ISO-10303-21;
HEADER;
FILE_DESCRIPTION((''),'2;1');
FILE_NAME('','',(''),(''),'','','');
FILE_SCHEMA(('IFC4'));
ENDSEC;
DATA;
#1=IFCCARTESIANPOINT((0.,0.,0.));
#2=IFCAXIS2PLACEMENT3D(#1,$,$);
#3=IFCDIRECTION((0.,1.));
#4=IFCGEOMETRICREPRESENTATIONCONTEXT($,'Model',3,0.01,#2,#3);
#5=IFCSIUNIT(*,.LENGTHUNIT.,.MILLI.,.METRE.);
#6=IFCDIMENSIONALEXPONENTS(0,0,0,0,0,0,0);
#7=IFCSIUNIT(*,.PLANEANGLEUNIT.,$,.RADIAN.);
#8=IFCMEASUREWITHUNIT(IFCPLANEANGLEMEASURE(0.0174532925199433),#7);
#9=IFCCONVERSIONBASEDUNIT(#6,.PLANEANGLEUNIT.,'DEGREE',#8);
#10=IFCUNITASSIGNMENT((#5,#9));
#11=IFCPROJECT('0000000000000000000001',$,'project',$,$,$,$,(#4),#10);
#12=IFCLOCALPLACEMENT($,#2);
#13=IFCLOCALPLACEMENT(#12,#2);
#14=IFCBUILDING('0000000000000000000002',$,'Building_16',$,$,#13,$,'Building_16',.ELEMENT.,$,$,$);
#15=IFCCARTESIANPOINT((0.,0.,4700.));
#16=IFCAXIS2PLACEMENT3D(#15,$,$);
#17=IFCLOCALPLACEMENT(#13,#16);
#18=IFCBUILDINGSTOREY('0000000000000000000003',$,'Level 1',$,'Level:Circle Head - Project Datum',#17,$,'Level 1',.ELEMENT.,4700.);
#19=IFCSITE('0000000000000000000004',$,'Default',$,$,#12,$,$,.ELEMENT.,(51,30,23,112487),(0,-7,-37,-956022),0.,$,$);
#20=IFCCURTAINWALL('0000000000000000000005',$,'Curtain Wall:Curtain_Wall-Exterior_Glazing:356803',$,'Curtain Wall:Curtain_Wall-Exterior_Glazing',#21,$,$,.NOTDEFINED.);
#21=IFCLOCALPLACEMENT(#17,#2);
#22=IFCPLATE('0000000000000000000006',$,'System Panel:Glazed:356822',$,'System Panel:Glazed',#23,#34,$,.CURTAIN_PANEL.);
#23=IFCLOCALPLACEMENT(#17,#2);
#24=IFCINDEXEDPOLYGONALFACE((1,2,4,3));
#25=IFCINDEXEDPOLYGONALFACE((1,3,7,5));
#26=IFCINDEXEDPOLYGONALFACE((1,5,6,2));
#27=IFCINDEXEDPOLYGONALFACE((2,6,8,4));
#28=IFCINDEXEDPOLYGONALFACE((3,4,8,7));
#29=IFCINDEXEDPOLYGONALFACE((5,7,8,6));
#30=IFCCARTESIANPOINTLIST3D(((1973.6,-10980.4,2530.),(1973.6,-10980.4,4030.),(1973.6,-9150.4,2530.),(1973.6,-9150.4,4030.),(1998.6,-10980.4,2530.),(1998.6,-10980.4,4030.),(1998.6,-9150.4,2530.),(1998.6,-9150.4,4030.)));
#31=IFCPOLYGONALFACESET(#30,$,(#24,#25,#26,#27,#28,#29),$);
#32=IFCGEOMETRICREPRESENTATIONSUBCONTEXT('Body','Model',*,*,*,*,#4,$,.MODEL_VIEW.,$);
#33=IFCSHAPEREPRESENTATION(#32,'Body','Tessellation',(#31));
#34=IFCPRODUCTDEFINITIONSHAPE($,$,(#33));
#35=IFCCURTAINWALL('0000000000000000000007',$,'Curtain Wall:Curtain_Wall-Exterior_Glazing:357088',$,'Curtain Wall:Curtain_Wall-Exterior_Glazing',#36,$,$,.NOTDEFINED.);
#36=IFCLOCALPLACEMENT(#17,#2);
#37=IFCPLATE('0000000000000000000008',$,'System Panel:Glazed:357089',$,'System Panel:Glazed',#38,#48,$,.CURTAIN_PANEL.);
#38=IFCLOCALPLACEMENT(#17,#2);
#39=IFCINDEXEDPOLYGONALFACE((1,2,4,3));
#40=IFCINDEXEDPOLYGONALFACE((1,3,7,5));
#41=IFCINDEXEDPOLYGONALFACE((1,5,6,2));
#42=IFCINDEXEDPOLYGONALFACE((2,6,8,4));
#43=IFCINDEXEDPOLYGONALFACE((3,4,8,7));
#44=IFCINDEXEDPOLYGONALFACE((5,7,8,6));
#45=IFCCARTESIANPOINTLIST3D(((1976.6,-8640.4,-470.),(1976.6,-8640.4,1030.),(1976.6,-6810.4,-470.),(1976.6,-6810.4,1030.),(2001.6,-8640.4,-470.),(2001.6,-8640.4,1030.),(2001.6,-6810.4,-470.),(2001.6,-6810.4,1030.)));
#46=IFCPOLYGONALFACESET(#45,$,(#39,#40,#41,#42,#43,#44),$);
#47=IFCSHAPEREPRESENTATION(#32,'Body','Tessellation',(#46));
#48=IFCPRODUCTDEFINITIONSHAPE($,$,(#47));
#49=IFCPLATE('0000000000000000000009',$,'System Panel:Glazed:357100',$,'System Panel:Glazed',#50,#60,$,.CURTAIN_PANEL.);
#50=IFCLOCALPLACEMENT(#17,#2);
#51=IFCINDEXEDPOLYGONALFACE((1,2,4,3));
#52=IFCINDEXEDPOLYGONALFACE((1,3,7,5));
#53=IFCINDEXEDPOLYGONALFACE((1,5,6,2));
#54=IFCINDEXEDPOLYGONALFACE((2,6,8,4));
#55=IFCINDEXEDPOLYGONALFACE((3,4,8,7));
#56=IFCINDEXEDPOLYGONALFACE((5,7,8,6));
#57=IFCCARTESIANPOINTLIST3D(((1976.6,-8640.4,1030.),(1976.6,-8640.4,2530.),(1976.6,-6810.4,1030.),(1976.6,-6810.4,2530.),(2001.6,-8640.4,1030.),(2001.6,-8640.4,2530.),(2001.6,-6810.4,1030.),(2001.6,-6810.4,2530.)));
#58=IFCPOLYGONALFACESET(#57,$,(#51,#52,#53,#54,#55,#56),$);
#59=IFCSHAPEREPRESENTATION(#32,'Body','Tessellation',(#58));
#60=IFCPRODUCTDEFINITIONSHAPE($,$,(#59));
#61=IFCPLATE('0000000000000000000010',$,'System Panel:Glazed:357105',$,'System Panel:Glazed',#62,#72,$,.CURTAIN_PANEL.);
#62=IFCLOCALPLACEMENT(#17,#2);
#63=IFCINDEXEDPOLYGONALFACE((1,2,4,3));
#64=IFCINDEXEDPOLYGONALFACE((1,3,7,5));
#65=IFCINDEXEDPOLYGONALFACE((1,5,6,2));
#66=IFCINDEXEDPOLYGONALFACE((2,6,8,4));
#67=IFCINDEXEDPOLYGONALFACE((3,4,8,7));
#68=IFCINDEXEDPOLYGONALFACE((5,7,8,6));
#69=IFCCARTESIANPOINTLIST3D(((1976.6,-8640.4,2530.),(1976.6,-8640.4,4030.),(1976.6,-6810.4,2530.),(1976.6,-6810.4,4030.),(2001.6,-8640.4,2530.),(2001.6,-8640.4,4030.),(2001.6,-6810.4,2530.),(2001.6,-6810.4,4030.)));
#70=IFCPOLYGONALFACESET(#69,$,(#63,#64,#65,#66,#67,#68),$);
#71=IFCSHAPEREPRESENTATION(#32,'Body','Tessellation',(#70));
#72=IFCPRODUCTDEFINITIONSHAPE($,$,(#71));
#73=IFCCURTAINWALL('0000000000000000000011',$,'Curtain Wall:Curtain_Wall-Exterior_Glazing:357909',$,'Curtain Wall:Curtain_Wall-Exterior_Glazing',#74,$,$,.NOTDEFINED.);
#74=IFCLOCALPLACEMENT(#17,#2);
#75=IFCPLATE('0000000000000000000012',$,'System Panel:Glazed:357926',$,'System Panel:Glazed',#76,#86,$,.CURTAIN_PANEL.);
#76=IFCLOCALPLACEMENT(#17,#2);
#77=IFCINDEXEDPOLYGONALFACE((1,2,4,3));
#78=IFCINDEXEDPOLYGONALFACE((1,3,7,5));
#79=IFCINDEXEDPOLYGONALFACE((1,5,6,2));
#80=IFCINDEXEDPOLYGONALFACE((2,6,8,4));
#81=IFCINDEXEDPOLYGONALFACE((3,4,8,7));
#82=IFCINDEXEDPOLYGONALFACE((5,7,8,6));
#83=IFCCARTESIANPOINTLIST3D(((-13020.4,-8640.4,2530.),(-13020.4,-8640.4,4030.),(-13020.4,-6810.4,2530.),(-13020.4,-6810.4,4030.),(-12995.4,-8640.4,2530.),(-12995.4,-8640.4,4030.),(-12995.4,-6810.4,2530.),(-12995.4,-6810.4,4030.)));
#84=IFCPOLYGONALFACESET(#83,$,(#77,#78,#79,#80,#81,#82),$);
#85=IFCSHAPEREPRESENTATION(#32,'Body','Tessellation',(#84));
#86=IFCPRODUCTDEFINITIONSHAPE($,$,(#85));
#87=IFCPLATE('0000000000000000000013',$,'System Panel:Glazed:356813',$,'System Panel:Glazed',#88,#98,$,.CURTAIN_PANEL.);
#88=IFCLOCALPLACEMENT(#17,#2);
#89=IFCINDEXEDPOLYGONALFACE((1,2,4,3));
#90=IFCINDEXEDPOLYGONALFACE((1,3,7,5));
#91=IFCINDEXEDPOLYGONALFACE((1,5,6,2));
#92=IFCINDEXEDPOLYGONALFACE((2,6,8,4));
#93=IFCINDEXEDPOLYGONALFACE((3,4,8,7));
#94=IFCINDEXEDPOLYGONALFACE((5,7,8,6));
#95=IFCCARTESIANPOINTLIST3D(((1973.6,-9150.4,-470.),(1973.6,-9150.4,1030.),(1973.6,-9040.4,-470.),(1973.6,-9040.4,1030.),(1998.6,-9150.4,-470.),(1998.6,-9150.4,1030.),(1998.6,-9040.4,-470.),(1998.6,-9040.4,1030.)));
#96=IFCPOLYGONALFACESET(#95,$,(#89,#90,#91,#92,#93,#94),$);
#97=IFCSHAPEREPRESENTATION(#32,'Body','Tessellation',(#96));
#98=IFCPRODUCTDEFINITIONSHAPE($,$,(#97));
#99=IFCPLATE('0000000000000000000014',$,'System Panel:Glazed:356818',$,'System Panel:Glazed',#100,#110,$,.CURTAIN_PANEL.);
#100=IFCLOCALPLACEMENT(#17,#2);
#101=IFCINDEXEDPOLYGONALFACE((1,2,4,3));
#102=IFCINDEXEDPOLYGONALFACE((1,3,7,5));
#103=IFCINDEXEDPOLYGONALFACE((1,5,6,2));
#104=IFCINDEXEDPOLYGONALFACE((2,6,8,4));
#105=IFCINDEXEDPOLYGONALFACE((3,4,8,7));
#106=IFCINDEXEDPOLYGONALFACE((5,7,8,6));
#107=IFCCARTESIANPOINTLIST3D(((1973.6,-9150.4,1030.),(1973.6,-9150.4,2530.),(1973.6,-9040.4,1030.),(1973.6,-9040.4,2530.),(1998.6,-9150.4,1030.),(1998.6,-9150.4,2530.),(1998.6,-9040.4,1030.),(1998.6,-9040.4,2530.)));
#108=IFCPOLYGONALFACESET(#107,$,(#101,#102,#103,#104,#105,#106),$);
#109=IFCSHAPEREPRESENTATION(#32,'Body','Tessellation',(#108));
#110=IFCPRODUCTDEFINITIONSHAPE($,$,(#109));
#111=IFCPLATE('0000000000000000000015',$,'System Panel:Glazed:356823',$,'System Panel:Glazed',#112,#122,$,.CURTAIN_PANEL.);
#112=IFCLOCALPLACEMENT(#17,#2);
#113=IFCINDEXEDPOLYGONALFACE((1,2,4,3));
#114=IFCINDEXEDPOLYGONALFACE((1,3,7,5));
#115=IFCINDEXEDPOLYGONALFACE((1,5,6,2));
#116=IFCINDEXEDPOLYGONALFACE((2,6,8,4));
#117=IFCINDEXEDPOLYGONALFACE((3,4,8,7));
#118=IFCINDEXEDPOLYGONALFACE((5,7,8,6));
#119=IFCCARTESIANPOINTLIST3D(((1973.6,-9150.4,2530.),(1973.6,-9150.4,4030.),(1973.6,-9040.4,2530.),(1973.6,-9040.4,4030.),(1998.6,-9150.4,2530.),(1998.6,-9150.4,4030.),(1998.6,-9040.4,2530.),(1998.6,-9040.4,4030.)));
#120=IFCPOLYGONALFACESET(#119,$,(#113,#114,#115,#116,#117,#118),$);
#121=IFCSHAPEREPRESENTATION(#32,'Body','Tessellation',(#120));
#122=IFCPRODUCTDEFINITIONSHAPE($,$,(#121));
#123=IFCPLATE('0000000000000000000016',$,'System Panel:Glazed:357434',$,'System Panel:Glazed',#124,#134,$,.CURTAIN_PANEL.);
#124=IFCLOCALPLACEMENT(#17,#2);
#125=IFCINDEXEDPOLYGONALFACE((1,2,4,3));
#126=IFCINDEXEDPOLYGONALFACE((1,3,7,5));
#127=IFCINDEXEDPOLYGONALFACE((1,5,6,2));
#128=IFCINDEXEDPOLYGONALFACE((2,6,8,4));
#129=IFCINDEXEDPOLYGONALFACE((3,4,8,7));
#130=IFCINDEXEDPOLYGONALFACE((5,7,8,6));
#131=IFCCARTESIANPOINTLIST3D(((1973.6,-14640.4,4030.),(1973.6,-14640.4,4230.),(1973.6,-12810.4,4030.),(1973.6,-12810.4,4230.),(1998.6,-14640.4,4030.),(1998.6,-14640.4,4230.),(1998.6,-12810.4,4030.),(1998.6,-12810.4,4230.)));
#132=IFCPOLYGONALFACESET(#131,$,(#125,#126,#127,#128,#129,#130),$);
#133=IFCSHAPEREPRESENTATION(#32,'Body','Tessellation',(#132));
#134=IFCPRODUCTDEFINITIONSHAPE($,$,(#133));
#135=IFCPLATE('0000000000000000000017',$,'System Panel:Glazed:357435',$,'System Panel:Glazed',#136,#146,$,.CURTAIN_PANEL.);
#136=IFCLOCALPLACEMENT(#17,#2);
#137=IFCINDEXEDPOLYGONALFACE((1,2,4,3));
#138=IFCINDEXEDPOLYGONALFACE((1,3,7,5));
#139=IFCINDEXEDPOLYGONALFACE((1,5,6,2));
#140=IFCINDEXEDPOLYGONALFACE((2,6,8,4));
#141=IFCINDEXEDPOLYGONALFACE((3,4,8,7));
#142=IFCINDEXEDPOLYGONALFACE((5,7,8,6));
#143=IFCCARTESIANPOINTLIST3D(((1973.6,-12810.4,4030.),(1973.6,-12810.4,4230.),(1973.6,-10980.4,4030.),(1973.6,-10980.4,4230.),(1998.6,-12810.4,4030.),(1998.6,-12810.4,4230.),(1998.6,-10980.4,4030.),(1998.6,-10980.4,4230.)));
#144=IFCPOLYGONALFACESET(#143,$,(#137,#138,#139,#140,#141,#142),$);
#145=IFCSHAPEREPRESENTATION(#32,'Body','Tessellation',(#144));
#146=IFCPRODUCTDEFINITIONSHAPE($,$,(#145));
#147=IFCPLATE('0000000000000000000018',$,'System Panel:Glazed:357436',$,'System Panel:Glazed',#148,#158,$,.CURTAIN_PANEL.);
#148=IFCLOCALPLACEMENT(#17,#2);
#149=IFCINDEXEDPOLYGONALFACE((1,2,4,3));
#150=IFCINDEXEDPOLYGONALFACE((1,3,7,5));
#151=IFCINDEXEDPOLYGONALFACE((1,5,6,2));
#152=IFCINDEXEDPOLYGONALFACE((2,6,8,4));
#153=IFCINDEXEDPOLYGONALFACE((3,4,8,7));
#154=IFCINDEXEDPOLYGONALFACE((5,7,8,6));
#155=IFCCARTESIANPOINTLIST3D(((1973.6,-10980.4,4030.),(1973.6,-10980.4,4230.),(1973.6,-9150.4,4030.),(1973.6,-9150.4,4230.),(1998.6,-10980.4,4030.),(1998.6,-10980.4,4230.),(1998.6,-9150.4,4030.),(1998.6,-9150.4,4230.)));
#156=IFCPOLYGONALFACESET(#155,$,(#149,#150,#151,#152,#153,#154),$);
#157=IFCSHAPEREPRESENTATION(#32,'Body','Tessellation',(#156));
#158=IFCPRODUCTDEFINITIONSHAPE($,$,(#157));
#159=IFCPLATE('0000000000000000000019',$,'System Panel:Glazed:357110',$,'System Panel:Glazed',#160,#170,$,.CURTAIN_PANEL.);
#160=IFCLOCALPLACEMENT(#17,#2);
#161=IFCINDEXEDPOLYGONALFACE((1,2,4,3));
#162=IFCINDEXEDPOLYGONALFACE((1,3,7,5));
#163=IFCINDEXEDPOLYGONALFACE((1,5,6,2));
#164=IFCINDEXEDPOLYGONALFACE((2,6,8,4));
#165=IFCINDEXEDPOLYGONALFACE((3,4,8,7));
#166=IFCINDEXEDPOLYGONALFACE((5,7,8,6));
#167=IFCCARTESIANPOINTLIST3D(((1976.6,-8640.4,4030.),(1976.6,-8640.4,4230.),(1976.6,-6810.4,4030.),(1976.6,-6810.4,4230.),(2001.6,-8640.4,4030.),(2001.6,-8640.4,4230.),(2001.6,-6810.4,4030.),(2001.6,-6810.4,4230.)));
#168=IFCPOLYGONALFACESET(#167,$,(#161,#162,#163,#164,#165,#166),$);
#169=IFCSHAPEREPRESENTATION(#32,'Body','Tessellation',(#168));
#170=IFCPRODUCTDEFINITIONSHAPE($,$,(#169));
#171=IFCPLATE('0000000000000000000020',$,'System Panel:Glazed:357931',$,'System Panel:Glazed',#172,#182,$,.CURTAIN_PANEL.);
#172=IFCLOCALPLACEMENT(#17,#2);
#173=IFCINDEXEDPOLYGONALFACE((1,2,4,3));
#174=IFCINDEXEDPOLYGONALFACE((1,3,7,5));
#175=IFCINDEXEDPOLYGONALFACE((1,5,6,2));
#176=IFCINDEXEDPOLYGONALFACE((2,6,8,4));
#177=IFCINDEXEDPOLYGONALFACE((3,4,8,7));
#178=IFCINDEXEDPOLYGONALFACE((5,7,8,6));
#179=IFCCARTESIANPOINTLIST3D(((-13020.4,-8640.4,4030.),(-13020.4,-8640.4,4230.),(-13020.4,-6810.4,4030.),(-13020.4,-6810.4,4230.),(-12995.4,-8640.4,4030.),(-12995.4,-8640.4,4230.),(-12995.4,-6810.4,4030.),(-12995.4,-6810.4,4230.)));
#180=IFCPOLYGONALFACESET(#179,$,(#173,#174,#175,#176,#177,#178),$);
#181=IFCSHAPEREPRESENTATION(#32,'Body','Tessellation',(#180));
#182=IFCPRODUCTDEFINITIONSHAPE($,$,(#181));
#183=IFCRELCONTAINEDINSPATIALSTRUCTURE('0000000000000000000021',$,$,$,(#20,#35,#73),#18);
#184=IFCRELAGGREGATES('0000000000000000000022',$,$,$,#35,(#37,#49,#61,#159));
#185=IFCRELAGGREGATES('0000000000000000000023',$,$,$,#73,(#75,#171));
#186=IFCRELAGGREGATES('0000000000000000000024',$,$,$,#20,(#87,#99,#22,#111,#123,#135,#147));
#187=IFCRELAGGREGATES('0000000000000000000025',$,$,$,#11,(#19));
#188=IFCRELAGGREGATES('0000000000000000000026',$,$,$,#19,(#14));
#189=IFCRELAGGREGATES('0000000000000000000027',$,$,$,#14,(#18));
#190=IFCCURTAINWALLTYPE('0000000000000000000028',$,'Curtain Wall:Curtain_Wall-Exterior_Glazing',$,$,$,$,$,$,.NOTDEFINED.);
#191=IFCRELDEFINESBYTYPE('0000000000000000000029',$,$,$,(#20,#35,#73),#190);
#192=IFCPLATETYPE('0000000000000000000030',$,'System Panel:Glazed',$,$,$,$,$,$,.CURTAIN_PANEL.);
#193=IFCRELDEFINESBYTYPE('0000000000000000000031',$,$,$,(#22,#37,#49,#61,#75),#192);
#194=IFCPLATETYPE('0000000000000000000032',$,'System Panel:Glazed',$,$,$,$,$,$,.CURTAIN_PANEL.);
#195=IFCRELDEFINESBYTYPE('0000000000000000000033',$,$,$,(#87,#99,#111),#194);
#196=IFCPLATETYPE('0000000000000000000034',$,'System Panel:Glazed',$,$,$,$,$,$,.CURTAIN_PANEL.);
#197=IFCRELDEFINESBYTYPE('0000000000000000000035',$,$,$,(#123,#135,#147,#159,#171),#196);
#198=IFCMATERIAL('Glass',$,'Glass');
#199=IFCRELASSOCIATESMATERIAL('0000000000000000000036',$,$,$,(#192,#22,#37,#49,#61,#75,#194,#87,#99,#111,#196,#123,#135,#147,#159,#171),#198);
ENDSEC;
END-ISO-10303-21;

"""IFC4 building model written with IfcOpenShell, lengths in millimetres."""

from ifc_helpers import new_model, entity, si_unit, converted_unit, direction, frame, origin, place, context, subcontext, project, spatial, indexed_curve, outline, extrude, source, transform, mapped, material, type_object, type_shapes, element, aggregate, save


model = new_model("IFC4")

# Units and contexts
model_context = context("Model", 3, precision=0.01, world=origin(), true_north=direction((0.0, 1.0)))
body_context = subcontext(model_context, "Body", "Model", "MODEL_VIEW")
ifc_project = project(units=[si_unit("LENGTHUNIT", "METRE", prefix="MILLI"), converted_unit("PLANEANGLEUNIT", "DEGREE", entity("IfcPlaneAngleMeasure", 0.0174532925199433), si_unit("PLANEANGLEUNIT", "RADIAN"), dimensions=[0, 0, 0, 0, 0, 0, 0])], contexts=[model_context])

# Site, building, storey
site_placement = place(None, origin())
site = spatial("IfcSite", under=ifc_project, at=site_placement, Name="Default", CompositionType="ELEMENT", RefLatitude=(51, 30, 23, 112487), RefLongitude=(0, -7, -37, -956022), RefElevation=0.0)
building_placement = place(site_placement, origin())
building = spatial("IfcBuilding", under=site, at=building_placement, Name="Building_16", LongName="Building_16", CompositionType="ELEMENT")
storey_placement = place(building_placement, frame((0.0, 0.0, 4700.0)))
storey = spatial("IfcBuildingStorey", under=building, at=storey_placement, Name="Level 1", ObjectType="Level:Circle Head - Project Datum", LongName="Level 1", CompositionType="ELEMENT", Elevation=4700.0)

# Curtain walls, plates
curtain_wall_type = type_object("IfcCurtainWallType", Name="Curtain Wall:Curtain_Wall-Exterior_Glazing", PredefinedType="NOTDEFINED")
curtain_wall_1_placement = place(storey_placement, frame((0.0, 0.0, -4700.0)))
curtain_wall_1 = element("IfcCurtainWall", 1, at=curtain_wall_1_placement, inside=storey, type_object=curtain_wall_type, Name="Curtain Wall:Curtain_Wall-Exterior_Glazing:356803", ObjectType="Curtain Wall:Curtain_Wall-Exterior_Glazing", PredefinedType="NOTDEFINED")
ifc_material_1 = material(Name="Glass", Category="Glass")
plate_type_1 = type_object("IfcPlateType", Name="System Panel:Glazed", PredefinedType="CURTAIN_PANEL", material=ifc_material_1)
shared_shape_1 = source(origin(), body_context, "Body", "SweptSolid", [
    extrude(outline(indexed_curve([(-12.5, -915.0), (12.5, -915.0), (12.5, 915.0), (-12.5, 915.0), (-12.5, -915.0)], self_intersect=False)), frame((0.0, 37.0, 0.0), z_axis=(0.0, 0.0, 1.0), x_axis=(0.0, 1.0, 0.0)), (0.0, 0.0, 1.0), 1500.0),
])
type_shapes(plate_type_1, [shared_shape_1])
plate_1_placement = place(curtain_wall_1_placement, frame((2023.1, -10065.4, 7230.0), z_axis=(0.0, 0.0, 1.0), x_axis=(0.0, 1.0, 0.0)))
plate_1 = element("IfcPlate", 2, at=plate_1_placement, type_object=plate_type_1, material=ifc_material_1, Name="System Panel:Glazed:356822", ObjectType="System Panel:Glazed", PredefinedType="CURTAIN_PANEL", context=body_context, shape_type="MappedRepresentation", body=[
    mapped(shared_shape_1, transform((0.0, 0.0, 0.0), scale=1.0)),
])
curtain_wall_2_placement = place(storey_placement, frame((0.0, 0.0, -4700.0)))
curtain_wall_2 = element("IfcCurtainWall", 3, at=curtain_wall_2_placement, inside=storey, type_object=curtain_wall_type, Name="Curtain Wall:Curtain_Wall-Exterior_Glazing:357088", ObjectType="Curtain Wall:Curtain_Wall-Exterior_Glazing", PredefinedType="NOTDEFINED")
plate_2_placement = place(curtain_wall_2_placement, frame((2026.1, -7725.4, 4230.0), z_axis=(0.0, 0.0, 1.0), x_axis=(0.0, 1.0, 0.0)))
plate_2 = element("IfcPlate", 4, at=plate_2_placement, type_object=plate_type_1, material=ifc_material_1, Name="System Panel:Glazed:357089", ObjectType="System Panel:Glazed", PredefinedType="CURTAIN_PANEL", context=body_context, shape_type="MappedRepresentation", body=[
    mapped(shared_shape_1, transform((0.0, 0.0, 0.0), scale=1.0)),
])
plate_3_placement = place(curtain_wall_2_placement, frame((2026.1, -7725.4, 5730.0), z_axis=(0.0, 0.0, 1.0), x_axis=(0.0, 1.0, 0.0)))
plate_3 = element("IfcPlate", 5, at=plate_3_placement, type_object=plate_type_1, material=ifc_material_1, Name="System Panel:Glazed:357100", ObjectType="System Panel:Glazed", PredefinedType="CURTAIN_PANEL", context=body_context, shape_type="MappedRepresentation", body=[
    mapped(shared_shape_1, transform((0.0, 0.0, 0.0), scale=1.0)),
])
plate_4_placement = place(curtain_wall_2_placement, frame((2026.1, -7725.4, 7230.0), z_axis=(0.0, 0.0, 1.0), x_axis=(0.0, 1.0, 0.0)))
plate_4 = element("IfcPlate", 6, at=plate_4_placement, type_object=plate_type_1, material=ifc_material_1, Name="System Panel:Glazed:357105", ObjectType="System Panel:Glazed", PredefinedType="CURTAIN_PANEL", context=body_context, shape_type="MappedRepresentation", body=[
    mapped(shared_shape_1, transform((0.0, 0.0, 0.0), scale=1.0)),
])

# Curtain wall, plate
curtain_wall_3_placement = place(storey_placement, frame((0.0, 0.0, -4700.0)))
curtain_wall_3 = element("IfcCurtainWall", 7, at=curtain_wall_3_placement, inside=storey, type_object=curtain_wall_type, Name="Curtain Wall:Curtain_Wall-Exterior_Glazing:357909", ObjectType="Curtain Wall:Curtain_Wall-Exterior_Glazing", PredefinedType="NOTDEFINED")
plate_5_placement = place(curtain_wall_3_placement, frame((-12970.9, -7725.4, 7230.0), z_axis=(0.0, 0.0, 1.0), x_axis=(0.0, 1.0, 0.0)))
plate_5 = element("IfcPlate", 8, at=plate_5_placement, type_object=plate_type_1, material=ifc_material_1, Name="System Panel:Glazed:357926", ObjectType="System Panel:Glazed", PredefinedType="CURTAIN_PANEL", context=body_context, shape_type="MappedRepresentation", body=[
    mapped(shared_shape_1, transform((0.0, 0.0, 0.0), scale=1.0)),
])

# Plates
plate_type_2 = type_object("IfcPlateType", Name="System Panel:Glazed", PredefinedType="CURTAIN_PANEL", material=ifc_material_1)
shared_shape_2 = source(origin(), body_context, "Body", "SweptSolid", [
    extrude(outline(indexed_curve([(-12.5, -55.0), (12.5, -55.0), (12.5, 55.0), (-12.5, 55.0), (-12.5, -55.0)], self_intersect=False)), frame((0.0, 37.0, 0.0), z_axis=(0.0, 0.0, 1.0), x_axis=(0.0, 1.0, 0.0)), (0.0, 0.0, 1.0), 1500.0),
])
type_shapes(plate_type_2, [shared_shape_2])
plate_6_placement = place(curtain_wall_1_placement, frame((2023.1, -9095.4, 4230.0), z_axis=(0.0, 0.0, 1.0), x_axis=(0.0, 1.0, 0.0)))
plate_6 = element("IfcPlate", 9, at=plate_6_placement, type_object=plate_type_2, material=ifc_material_1, Name="System Panel:Glazed:356813", ObjectType="System Panel:Glazed", PredefinedType="CURTAIN_PANEL", context=body_context, shape_type="MappedRepresentation", body=[
    mapped(shared_shape_2, transform((0.0, 0.0, 0.0), scale=1.0)),
])
plate_7_placement = place(curtain_wall_1_placement, frame((2023.1, -9095.4, 5730.0), z_axis=(0.0, 0.0, 1.0), x_axis=(0.0, 1.0, 0.0)))
plate_7 = element("IfcPlate", 10, at=plate_7_placement, type_object=plate_type_2, material=ifc_material_1, Name="System Panel:Glazed:356818", ObjectType="System Panel:Glazed", PredefinedType="CURTAIN_PANEL", context=body_context, shape_type="MappedRepresentation", body=[
    mapped(shared_shape_2, transform((0.0, 0.0, 0.0), scale=1.0)),
])
plate_8_placement = place(curtain_wall_1_placement, frame((2023.1, -9095.4, 7230.0), z_axis=(0.0, 0.0, 1.0), x_axis=(0.0, 1.0, 0.0)))
plate_8 = element("IfcPlate", 11, at=plate_8_placement, type_object=plate_type_2, material=ifc_material_1, Name="System Panel:Glazed:356823", ObjectType="System Panel:Glazed", PredefinedType="CURTAIN_PANEL", context=body_context, shape_type="MappedRepresentation", body=[
    mapped(shared_shape_2, transform((0.0, 0.0, 0.0), scale=1.0)),
])
plate_type_3 = type_object("IfcPlateType", Name="System Panel:Glazed", PredefinedType="CURTAIN_PANEL", material=ifc_material_1)
shared_shape_3 = source(origin(), body_context, "Body", "SweptSolid", [
    extrude(outline(indexed_curve([(-12.5, -915.0), (12.5, -915.0), (12.5, 915.0), (-12.5, 915.0), (-12.5, -915.0)], self_intersect=False)), frame((0.0, 37.0, 0.0), z_axis=(0.0, 0.0, 1.0), x_axis=(0.0, 1.0, 0.0)), (0.0, 0.0, 1.0), 200.0),
])
type_shapes(plate_type_3, [shared_shape_3])
plate_9_placement = place(curtain_wall_1_placement, frame((2023.1, -13725.4, 8730.0), z_axis=(0.0, 0.0, 1.0), x_axis=(0.0, 1.0, 0.0)))
plate_9 = element("IfcPlate", 12, at=plate_9_placement, type_object=plate_type_3, material=ifc_material_1, Name="System Panel:Glazed:357434", ObjectType="System Panel:Glazed", PredefinedType="CURTAIN_PANEL", context=body_context, shape_type="MappedRepresentation", body=[
    mapped(shared_shape_3, transform((0.0, 0.0, 0.0), scale=1.0)),
])
plate_10_placement = place(curtain_wall_1_placement, frame((2023.1, -11895.4, 8730.0), z_axis=(0.0, 0.0, 1.0), x_axis=(0.0, 1.0, 0.0)))
plate_10 = element("IfcPlate", 13, at=plate_10_placement, type_object=plate_type_3, material=ifc_material_1, Name="System Panel:Glazed:357435", ObjectType="System Panel:Glazed", PredefinedType="CURTAIN_PANEL", context=body_context, shape_type="MappedRepresentation", body=[
    mapped(shared_shape_3, transform((0.0, 0.0, 0.0), scale=1.0)),
])
plate_11_placement = place(curtain_wall_1_placement, frame((2023.1, -10065.4, 8730.0), z_axis=(0.0, 0.0, 1.0), x_axis=(0.0, 1.0, 0.0)))
plate_11 = element("IfcPlate", 14, at=plate_11_placement, type_object=plate_type_3, material=ifc_material_1, Name="System Panel:Glazed:357436", ObjectType="System Panel:Glazed", PredefinedType="CURTAIN_PANEL", context=body_context, shape_type="MappedRepresentation", body=[
    mapped(shared_shape_3, transform((0.0, 0.0, 0.0), scale=1.0)),
])
plate_12_placement = place(curtain_wall_2_placement, frame((2026.1, -7725.4, 8730.0), z_axis=(0.0, 0.0, 1.0), x_axis=(0.0, 1.0, 0.0)))
plate_12 = element("IfcPlate", 15, at=plate_12_placement, type_object=plate_type_3, material=ifc_material_1, Name="System Panel:Glazed:357110", ObjectType="System Panel:Glazed", PredefinedType="CURTAIN_PANEL", context=body_context, shape_type="MappedRepresentation", body=[
    mapped(shared_shape_3, transform((0.0, 0.0, 0.0), scale=1.0)),
])
aggregate(curtain_wall_2, [plate_2, plate_3, plate_4, plate_12])
plate_13_placement = place(curtain_wall_3_placement, frame((-12970.9, -7725.4, 8730.0), z_axis=(0.0, 0.0, 1.0), x_axis=(0.0, 1.0, 0.0)))
plate_13 = element("IfcPlate", 16, at=plate_13_placement, type_object=plate_type_3, material=ifc_material_1, Name="System Panel:Glazed:357931", ObjectType="System Panel:Glazed", PredefinedType="CURTAIN_PANEL", context=body_context, shape_type="MappedRepresentation", body=[
    mapped(shared_shape_3, transform((0.0, 0.0, 0.0), scale=1.0)),
])
aggregate(curtain_wall_3, [plate_5, plate_13])
aggregate(curtain_wall_1, [plate_6, plate_7, plate_1, plate_8, plate_9, plate_10, plate_11])

save(model, "model.ifc")
